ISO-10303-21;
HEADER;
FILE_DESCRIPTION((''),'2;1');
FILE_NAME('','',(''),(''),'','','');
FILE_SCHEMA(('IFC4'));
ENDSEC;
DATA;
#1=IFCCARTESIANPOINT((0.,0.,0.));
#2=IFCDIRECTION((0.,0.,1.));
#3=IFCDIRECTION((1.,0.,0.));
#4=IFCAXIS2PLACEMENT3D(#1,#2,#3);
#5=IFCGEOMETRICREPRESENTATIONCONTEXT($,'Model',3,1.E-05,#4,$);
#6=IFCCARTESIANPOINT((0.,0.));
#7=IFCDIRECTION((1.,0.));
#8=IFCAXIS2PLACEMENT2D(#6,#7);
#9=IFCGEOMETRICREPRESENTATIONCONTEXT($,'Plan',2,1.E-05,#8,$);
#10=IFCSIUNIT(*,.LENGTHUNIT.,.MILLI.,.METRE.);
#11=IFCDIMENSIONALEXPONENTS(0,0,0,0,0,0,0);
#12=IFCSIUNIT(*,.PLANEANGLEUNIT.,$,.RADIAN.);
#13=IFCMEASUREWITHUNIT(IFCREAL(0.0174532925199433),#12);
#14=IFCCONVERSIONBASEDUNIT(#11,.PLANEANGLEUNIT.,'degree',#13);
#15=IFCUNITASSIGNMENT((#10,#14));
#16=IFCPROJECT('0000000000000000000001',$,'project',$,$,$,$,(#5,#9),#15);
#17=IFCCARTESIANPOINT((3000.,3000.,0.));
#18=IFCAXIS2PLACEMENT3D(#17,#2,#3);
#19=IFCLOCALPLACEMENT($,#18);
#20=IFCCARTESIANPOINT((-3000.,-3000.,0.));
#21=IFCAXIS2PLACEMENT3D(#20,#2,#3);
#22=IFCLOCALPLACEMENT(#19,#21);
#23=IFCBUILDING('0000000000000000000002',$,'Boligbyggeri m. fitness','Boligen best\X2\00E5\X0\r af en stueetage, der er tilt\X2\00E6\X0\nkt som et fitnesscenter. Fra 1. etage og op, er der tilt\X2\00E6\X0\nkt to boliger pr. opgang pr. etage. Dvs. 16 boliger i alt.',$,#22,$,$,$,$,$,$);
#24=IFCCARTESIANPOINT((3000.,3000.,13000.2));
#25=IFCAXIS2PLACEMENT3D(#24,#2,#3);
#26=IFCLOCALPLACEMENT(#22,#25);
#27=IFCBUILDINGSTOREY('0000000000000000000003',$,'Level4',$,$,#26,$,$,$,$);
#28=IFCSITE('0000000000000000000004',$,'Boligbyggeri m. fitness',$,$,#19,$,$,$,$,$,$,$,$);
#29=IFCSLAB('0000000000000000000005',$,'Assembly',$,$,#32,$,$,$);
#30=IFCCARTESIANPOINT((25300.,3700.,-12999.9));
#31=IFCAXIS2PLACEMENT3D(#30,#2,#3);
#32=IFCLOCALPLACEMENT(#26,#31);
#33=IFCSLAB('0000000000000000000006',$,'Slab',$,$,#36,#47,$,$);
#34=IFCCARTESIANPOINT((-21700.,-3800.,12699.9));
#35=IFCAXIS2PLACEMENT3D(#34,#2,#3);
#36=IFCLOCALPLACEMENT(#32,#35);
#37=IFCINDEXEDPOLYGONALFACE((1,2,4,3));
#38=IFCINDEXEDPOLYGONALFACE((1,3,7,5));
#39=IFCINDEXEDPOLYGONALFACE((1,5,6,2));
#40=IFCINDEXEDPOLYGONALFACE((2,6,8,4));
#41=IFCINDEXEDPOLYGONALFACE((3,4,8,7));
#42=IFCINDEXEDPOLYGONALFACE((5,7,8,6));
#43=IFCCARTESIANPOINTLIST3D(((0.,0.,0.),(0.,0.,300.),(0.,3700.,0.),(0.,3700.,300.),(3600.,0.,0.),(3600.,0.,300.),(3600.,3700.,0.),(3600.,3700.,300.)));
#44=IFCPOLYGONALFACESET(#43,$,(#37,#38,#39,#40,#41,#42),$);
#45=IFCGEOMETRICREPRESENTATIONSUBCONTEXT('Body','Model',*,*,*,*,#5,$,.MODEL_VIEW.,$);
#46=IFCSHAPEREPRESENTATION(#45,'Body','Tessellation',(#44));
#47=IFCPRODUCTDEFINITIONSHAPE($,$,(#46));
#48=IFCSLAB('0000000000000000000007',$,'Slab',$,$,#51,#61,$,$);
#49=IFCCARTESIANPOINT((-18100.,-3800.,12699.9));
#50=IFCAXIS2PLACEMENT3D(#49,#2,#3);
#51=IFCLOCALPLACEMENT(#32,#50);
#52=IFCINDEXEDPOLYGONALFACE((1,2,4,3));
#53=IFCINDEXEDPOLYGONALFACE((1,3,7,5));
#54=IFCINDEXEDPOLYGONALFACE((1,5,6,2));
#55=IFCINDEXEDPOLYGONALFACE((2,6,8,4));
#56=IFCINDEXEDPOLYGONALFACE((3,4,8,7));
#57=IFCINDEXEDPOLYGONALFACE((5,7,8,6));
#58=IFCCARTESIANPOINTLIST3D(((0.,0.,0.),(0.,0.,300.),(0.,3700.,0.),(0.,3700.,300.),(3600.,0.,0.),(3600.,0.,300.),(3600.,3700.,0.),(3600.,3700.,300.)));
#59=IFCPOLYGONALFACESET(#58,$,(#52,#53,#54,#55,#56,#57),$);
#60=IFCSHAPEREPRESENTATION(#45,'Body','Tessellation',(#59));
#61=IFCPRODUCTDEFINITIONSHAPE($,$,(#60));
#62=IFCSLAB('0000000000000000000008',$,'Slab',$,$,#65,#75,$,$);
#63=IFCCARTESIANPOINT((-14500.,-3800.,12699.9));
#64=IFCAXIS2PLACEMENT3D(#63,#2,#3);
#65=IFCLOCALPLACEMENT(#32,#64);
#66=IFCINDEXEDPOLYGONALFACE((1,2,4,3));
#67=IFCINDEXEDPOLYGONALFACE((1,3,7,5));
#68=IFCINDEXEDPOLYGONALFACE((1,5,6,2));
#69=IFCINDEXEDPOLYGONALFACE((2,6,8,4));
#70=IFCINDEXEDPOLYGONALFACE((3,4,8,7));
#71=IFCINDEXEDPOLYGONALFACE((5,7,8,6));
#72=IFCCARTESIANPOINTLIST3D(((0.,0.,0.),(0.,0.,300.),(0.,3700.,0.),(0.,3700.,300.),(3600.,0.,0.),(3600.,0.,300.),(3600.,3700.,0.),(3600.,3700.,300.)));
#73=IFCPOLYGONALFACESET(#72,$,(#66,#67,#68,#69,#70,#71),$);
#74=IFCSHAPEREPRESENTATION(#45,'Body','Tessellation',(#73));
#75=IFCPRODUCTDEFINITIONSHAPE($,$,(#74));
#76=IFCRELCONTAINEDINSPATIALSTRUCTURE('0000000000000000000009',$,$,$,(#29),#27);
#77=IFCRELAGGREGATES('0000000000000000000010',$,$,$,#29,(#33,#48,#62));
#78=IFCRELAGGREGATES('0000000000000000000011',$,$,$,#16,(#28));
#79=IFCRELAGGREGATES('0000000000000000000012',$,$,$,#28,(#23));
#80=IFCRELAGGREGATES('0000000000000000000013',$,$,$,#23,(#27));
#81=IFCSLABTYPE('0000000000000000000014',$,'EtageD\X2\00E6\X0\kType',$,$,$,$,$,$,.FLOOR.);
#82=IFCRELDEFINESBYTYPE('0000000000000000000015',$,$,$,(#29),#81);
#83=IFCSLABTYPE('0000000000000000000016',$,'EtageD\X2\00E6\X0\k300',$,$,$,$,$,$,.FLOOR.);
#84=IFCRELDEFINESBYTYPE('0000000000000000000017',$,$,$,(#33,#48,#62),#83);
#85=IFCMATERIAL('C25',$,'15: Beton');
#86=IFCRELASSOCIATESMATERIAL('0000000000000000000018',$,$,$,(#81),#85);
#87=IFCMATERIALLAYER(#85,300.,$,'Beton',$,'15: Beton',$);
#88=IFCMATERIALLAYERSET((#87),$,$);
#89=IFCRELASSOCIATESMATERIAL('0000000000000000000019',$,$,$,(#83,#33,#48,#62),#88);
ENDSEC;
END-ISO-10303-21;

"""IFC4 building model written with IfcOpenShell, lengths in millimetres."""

from ifc_helpers import new_model, entity, si_unit, converted_unit, frame, origin_with_axes, origin_2d_with_axis, place, context, subcontext, project, spatial, line, indexed_curve, outline, extrude, material, layer, layer_set, layer_usage, type_object, element, aggregate, save


model = new_model("IFC4")

# Units and contexts
model_context = context("Model", 3, precision=1e-05, world=origin_with_axes())
plan_context = context("Plan", 2, precision=1e-05, world=origin_2d_with_axis())
body_context = subcontext(model_context, "Body", "Model", "MODEL_VIEW")
ifc_project = project(units=[si_unit("LENGTHUNIT", "METRE", prefix="MILLI"), converted_unit("PLANEANGLEUNIT", "degree", entity("IfcReal", 0.0174532925199433), si_unit("PLANEANGLEUNIT", "RADIAN"), dimensions=[0, 0, 0, 0, 0, 0, 0])], contexts=[model_context, plan_context])

# Site, building, storey
site_placement = place(None, frame((3000.0, 3000.0, 0.0), z_axis=(0.0, 0.0, 1.0), x_axis=(1.0, 0.0, 0.0)))
site = spatial("IfcSite", under=ifc_project, at=site_placement, Name="Boligbyggeri m. fitness")
building_placement = place(site_placement, frame((-3000.0, -3000.0, 0.0), z_axis=(0.0, 0.0, 1.0), x_axis=(1.0, 0.0, 0.0)))
building = spatial("IfcBuilding", under=site, at=building_placement, Name="Boligbyggeri m. fitness", Description="Boligen består af en stueetage, der er tiltænkt som et fitnesscenter. Fra 1. etage og op, er der tiltænkt to boliger pr. opgang pr. etage. Dvs. 16 boliger i alt.")
storey_placement = place(building_placement, frame((3000.0, 3000.0, 13000.2), z_axis=(0.0, 0.0, 1.0), x_axis=(1.0, 0.0, 0.0)))
storey = spatial("IfcBuildingStorey", under=building, at=storey_placement, Name="Level4")

# Shared definitions
ifc_material_1 = material(Name="C25", Category="15: Beton")

# Slabs
slab_type_1 = type_object("IfcSlabType", Name="EtageDækType", PredefinedType="FLOOR", material=ifc_material_1)
slab_1_placement = place(storey_placement, frame((25300.0, 3700.0, -12999.9), z_axis=(0.0, 0.0, 1.0), x_axis=(1.0, 0.0, 0.0)))
slab_1 = element("IfcSlab", 1, at=slab_1_placement, inside=storey, type_object=slab_type_1, Name="Assembly")
ifc_layer = layer(ifc_material_1, 300.0, Name="Beton", Category="15: Beton")
ifc_layer_set = layer_set([ifc_layer])
ifc_layer_usage_1 = layer_usage(ifc_layer_set, "AXIS3", "POSITIVE", 0.0)
slab_type_2 = type_object("IfcSlabType", Name="EtageDæk300", PredefinedType="FLOOR", material=ifc_layer_set)
slab_2_placement = place(slab_1_placement, frame((-21700.0, -3800.0, 12699.9), z_axis=(0.0, 0.0, 1.0), x_axis=(1.0, 0.0, 0.0)))
slab_2 = element("IfcSlab", 2, at=slab_2_placement, type_object=slab_type_2, material=ifc_layer_usage_1, Name="Slab", context=body_context, shape_type="SweptSolid", body=[
    extrude(outline(indexed_curve([(0.0, 0.0), (3600.0, 0.0), (3600.0, 3700.0), (0.0, 3700.0)], segments=[line(3, 2), line(2, 1), line(1, 4), line(4, 3)], self_intersect=False)), None, (0.0, 0.0, 1.0), 300.0),
])
ifc_layer_usage_2 = layer_usage(ifc_layer_set, "AXIS3", "POSITIVE", 0.0)
slab_3_placement = place(slab_1_placement, frame((-18100.0, -3800.0, 12699.9), z_axis=(0.0, 0.0, 1.0), x_axis=(1.0, 0.0, 0.0)))
slab_3 = element("IfcSlab", 3, at=slab_3_placement, type_object=slab_type_2, material=ifc_layer_usage_2, Name="Slab", context=body_context, shape_type="SweptSolid", body=[
    extrude(outline(indexed_curve([(0.0, 0.0), (3600.0, 0.0), (3600.0, 3700.0), (0.0, 3700.0)], segments=[line(3, 2), line(2, 1), line(1, 4), line(4, 3)], self_intersect=False)), None, (0.0, 0.0, 1.0), 300.0),
])
ifc_layer_usage_3 = layer_usage(ifc_layer_set, "AXIS3", "POSITIVE", 0.0)
slab_4_placement = place(slab_1_placement, frame((-14500.0, -3800.0, 12699.9), z_axis=(0.0, 0.0, 1.0), x_axis=(1.0, 0.0, 0.0)))
slab_4 = element("IfcSlab", 4, at=slab_4_placement, type_object=slab_type_2, material=ifc_layer_usage_3, Name="Slab", context=body_context, shape_type="SweptSolid", body=[
    extrude(outline(indexed_curve([(0.0, 0.0), (3600.0, 0.0), (3600.0, 3700.0), (0.0, 3700.0)], segments=[line(3, 2), line(2, 1), line(1, 4), line(4, 3)], self_intersect=False)), None, (0.0, 0.0, 1.0), 300.0),
])
aggregate(slab_1, [slab_2, slab_3, slab_4])

save(model, "model.ifc")
